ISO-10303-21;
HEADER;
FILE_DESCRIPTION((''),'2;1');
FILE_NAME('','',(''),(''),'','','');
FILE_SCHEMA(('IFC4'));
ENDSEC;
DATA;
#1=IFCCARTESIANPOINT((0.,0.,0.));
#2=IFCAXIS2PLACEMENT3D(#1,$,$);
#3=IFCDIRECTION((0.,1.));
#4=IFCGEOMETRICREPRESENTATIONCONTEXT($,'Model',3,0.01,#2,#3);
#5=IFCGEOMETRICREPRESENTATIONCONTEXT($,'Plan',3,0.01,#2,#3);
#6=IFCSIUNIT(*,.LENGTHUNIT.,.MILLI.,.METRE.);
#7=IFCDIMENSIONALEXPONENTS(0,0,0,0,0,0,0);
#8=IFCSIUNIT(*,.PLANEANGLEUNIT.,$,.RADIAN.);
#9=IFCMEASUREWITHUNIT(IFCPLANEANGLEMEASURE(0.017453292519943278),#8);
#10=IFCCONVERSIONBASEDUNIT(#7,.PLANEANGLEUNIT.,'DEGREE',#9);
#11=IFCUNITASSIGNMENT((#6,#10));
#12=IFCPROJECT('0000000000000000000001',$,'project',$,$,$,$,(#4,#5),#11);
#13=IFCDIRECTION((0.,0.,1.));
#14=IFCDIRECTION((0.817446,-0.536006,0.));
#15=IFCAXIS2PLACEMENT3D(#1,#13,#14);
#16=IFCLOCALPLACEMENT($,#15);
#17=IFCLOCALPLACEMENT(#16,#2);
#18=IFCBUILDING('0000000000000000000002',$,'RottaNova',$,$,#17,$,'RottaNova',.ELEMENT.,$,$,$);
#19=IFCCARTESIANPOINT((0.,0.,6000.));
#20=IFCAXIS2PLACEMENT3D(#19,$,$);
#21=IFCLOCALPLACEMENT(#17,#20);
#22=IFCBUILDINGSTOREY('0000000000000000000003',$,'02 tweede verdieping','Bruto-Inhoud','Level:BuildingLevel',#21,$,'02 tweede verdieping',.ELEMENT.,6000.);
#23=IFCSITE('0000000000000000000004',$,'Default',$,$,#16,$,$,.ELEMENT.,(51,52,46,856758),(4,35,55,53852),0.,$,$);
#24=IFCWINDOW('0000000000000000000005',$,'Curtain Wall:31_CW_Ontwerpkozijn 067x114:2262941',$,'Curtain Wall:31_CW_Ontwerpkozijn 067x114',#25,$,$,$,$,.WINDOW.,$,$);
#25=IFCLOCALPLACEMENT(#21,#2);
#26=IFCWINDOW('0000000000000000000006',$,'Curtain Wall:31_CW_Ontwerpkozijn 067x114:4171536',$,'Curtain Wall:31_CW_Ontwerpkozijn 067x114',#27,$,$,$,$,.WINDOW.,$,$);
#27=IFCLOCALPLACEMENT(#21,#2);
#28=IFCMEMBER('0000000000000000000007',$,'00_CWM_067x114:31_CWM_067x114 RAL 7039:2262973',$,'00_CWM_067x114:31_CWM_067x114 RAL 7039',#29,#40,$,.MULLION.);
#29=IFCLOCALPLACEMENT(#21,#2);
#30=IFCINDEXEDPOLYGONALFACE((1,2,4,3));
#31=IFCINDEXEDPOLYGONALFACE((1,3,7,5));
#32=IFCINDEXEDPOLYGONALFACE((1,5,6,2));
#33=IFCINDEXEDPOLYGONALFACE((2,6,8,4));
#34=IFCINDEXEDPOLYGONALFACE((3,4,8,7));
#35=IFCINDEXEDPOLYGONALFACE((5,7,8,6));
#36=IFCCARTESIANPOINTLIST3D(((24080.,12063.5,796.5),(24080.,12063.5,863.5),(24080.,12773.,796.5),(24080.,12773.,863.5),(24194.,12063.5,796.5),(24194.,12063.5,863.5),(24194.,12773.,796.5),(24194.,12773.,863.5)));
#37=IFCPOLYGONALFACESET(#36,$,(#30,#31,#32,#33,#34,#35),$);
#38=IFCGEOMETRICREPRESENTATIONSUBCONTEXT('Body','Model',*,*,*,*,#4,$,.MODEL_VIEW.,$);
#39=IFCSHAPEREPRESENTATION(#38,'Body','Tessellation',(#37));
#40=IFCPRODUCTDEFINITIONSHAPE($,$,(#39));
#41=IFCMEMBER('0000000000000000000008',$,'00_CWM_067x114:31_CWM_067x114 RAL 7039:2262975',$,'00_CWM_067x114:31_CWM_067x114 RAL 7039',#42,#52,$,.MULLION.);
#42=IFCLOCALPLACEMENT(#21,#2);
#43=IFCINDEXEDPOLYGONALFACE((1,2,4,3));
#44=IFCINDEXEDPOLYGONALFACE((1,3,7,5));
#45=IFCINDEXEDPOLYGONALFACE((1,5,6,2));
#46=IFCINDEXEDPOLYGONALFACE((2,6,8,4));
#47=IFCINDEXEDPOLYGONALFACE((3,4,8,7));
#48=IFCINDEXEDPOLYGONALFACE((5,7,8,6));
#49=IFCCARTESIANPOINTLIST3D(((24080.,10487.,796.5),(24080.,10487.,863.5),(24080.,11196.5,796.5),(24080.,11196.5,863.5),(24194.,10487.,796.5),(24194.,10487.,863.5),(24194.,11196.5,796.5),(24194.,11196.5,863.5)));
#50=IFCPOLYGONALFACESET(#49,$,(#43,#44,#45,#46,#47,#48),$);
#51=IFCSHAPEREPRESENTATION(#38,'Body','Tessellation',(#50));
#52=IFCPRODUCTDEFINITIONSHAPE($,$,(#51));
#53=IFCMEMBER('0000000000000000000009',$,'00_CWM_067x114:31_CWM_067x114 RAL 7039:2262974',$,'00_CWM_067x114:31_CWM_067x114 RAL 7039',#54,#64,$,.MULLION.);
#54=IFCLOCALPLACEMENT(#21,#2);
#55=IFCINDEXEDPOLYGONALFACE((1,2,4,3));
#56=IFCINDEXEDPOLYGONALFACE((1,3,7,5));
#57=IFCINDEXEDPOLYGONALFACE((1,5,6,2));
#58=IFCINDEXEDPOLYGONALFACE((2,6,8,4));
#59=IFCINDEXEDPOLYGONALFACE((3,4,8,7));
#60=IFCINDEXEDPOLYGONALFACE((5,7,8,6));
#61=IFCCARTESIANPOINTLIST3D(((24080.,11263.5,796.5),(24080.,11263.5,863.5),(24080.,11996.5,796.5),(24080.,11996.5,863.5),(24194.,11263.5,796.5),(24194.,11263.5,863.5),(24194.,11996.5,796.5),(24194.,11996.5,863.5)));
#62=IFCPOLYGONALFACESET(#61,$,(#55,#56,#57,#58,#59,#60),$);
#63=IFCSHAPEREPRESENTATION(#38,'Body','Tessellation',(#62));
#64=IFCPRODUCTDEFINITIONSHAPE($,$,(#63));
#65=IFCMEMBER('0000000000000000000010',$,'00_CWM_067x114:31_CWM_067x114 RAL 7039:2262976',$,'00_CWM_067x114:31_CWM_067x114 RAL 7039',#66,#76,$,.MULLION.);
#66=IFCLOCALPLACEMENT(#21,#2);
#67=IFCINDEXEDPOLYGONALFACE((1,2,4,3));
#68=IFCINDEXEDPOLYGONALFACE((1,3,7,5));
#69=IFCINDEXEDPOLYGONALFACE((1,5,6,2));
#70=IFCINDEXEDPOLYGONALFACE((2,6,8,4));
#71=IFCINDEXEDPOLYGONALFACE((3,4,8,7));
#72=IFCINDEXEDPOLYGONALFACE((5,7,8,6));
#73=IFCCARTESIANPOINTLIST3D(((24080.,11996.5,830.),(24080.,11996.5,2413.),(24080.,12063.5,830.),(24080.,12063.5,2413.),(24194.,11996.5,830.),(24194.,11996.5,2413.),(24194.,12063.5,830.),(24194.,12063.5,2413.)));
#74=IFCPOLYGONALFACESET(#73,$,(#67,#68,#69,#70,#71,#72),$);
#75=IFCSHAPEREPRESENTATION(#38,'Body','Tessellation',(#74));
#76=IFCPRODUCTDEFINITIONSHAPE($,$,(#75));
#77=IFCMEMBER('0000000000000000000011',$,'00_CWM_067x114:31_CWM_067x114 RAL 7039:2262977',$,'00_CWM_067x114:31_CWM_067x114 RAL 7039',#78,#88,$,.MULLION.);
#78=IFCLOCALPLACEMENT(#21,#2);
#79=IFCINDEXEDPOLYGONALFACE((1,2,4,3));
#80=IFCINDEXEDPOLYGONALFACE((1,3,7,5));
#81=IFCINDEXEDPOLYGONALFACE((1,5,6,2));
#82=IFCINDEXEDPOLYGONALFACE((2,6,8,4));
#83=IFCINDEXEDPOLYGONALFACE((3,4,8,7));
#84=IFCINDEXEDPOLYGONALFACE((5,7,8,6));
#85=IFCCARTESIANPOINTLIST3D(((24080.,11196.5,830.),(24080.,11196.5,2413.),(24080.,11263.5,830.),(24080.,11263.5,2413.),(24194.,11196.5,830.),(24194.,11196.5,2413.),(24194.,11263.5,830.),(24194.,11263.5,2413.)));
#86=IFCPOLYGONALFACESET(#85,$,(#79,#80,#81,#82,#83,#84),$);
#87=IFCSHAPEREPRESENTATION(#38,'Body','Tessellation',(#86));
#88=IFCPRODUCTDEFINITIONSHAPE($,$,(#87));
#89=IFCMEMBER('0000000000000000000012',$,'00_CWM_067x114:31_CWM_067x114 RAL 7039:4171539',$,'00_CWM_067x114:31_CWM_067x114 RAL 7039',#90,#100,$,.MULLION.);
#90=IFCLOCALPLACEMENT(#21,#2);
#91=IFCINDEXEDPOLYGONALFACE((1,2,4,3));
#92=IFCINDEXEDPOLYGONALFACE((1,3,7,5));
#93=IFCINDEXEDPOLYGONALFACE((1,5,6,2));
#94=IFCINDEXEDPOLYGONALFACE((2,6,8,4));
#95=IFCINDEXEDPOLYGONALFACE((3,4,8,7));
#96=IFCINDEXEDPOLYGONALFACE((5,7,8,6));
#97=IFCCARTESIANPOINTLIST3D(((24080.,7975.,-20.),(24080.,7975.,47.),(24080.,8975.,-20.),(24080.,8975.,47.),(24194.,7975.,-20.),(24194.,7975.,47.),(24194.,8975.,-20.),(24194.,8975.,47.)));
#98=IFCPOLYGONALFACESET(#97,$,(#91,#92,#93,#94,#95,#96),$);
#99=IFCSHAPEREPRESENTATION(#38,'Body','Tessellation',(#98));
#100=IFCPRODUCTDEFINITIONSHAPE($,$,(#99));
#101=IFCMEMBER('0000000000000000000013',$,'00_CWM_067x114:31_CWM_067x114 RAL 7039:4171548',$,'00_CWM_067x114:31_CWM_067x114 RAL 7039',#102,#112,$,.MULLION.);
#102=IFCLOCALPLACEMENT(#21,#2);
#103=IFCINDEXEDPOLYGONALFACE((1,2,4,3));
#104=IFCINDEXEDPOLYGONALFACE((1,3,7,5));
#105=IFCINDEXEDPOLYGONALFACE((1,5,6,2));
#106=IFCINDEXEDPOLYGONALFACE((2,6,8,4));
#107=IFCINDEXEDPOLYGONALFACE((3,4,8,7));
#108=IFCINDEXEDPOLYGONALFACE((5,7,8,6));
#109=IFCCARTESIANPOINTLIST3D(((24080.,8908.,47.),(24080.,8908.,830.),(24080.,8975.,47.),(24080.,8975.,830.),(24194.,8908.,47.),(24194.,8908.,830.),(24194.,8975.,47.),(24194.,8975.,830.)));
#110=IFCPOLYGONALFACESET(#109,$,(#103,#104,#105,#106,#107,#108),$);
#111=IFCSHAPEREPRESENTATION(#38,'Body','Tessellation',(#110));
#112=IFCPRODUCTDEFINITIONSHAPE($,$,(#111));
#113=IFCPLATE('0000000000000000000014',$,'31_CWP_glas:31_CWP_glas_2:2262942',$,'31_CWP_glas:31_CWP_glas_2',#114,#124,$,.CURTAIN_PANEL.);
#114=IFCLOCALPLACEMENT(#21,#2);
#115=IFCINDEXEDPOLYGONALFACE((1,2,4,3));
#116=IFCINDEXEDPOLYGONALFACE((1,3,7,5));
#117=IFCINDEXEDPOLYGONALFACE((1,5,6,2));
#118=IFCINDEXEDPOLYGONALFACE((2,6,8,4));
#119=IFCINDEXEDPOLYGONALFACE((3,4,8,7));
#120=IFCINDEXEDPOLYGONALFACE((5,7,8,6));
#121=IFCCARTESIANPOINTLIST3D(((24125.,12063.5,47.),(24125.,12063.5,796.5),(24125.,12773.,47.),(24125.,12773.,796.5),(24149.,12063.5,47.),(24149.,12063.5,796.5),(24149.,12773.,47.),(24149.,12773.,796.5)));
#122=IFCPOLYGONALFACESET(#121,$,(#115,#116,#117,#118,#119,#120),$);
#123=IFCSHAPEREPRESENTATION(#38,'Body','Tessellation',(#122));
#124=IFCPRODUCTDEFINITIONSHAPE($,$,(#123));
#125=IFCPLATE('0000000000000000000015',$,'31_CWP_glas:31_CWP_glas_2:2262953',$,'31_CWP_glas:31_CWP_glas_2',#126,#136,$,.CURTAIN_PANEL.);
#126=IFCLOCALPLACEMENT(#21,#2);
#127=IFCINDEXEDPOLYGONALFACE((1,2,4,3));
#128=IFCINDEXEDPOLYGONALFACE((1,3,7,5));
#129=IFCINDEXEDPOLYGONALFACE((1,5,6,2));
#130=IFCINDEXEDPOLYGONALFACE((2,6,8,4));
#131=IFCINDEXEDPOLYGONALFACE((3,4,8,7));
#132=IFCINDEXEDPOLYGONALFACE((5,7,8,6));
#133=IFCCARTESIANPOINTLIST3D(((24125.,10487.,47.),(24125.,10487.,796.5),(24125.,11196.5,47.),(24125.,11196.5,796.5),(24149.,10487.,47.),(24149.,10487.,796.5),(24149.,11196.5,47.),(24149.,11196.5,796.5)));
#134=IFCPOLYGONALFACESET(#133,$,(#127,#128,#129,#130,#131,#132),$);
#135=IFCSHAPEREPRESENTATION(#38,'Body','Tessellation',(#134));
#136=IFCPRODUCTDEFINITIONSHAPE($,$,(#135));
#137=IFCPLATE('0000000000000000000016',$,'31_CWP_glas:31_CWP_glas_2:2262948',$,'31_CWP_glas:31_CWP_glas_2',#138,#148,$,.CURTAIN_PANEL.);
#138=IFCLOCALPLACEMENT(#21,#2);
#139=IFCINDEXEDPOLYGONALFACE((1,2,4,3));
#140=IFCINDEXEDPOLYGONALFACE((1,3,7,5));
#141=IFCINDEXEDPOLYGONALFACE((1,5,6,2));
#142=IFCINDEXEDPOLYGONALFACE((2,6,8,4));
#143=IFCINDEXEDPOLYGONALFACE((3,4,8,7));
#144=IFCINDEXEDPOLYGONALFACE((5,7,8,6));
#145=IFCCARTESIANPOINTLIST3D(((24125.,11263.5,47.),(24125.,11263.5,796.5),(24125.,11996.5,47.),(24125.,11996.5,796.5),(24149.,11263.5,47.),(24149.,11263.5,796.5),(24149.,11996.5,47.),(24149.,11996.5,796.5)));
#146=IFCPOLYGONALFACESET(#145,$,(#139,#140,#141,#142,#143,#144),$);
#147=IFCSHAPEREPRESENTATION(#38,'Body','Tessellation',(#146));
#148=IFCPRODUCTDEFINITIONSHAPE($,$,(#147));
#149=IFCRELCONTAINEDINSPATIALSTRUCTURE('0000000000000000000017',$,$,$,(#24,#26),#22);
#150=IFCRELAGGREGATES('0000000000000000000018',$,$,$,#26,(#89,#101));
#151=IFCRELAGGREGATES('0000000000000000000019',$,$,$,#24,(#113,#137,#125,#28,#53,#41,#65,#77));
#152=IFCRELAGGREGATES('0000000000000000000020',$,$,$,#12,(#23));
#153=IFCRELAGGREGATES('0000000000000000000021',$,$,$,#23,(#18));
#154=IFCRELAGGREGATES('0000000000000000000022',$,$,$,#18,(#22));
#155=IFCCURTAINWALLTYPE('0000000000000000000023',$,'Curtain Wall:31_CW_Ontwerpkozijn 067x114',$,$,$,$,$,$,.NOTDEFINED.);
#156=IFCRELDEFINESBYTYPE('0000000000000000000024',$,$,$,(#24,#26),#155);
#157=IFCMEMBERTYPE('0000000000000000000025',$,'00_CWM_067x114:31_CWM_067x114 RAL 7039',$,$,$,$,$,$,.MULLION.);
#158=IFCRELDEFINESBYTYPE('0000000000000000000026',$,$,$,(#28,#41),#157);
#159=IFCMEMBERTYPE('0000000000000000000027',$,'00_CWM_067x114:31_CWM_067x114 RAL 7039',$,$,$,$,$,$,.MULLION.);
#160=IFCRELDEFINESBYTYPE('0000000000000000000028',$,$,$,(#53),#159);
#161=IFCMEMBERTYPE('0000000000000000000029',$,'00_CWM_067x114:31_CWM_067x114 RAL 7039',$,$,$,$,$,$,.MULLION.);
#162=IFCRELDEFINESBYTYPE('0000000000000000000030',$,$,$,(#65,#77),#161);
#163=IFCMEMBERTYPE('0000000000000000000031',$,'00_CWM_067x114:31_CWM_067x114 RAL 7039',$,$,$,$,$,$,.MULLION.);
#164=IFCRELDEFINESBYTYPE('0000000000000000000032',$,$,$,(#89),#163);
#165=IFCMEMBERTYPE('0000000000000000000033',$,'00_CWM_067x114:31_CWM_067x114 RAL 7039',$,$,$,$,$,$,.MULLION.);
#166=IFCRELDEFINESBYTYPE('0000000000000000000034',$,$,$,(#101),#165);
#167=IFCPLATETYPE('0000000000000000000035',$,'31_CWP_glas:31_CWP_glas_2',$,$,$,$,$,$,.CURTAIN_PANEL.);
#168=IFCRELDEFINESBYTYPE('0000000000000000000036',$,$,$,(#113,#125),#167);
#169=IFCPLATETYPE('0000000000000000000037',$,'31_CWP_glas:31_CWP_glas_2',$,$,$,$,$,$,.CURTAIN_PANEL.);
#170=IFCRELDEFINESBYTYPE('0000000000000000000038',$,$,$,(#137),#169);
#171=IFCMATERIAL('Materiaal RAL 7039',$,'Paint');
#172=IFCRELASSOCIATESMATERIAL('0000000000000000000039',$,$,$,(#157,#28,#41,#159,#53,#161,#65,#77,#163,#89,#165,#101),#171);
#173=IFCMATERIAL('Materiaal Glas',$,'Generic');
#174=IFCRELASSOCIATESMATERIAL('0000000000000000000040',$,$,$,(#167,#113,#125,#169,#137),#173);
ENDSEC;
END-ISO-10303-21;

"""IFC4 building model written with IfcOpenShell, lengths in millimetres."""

from ifc_helpers import new_model, entity, si_unit, converted_unit, direction, frame, origin, place, context, subcontext, project, spatial, indexed_curve, outline, extrude, source, transform, mapped, material, type_object, type_shapes, element, aggregate, save


model = new_model("IFC4")

# Units and contexts
model_context = context("Model", 3, precision=0.01, world=origin(), true_north=direction((0.0, 1.0)))
plan_context = context("Plan", 3, precision=0.01, world=origin(), true_north=direction((0.0, 1.0)))
body_context = subcontext(model_context, "Body", "Model", "MODEL_VIEW")
ifc_project = project(units=[si_unit("LENGTHUNIT", "METRE", prefix="MILLI"), converted_unit("PLANEANGLEUNIT", "DEGREE", entity("IfcPlaneAngleMeasure", 0.017453292519943278), si_unit("PLANEANGLEUNIT", "RADIAN"), dimensions=[0, 0, 0, 0, 0, 0, 0])], contexts=[model_context, plan_context])

# Site, building, storey
site_placement = place(None, frame((0.0, 0.0, 0.0), z_axis=(0.0, 0.0, 1.0), x_axis=(0.817446, -0.536006, 0.0)))
site = spatial("IfcSite", under=ifc_project, at=site_placement, Name="Default", CompositionType="ELEMENT", RefLatitude=(51, 52, 46, 856758), RefLongitude=(4, 35, 55, 53852), RefElevation=0.0)
building_placement = place(site_placement, origin())
building = spatial("IfcBuilding", under=site, at=building_placement, Name="RottaNova", LongName="RottaNova", CompositionType="ELEMENT")
storey_placement = place(building_placement, frame((0.0, 0.0, 6000.0)))
storey = spatial("IfcBuildingStorey", under=building, at=storey_placement, Name="02 tweede verdieping", Description="Bruto-Inhoud", ObjectType="Level:BuildingLevel", LongName="02 tweede verdieping", CompositionType="ELEMENT", Elevation=6000.0)

# Window
curtain_wall_type = type_object("IfcCurtainWallType", Name="Curtain Wall:31_CW_Ontwerpkozijn 067x114", PredefinedType="NOTDEFINED")
window_1_placement = place(storey_placement, frame((0.0, 0.0, -6000.0)))
window_1 = element("IfcWindow", 1, at=window_1_placement, inside=storey, type_object=curtain_wall_type, Name="Curtain Wall:31_CW_Ontwerpkozijn 067x114:2262941", ObjectType="Curtain Wall:31_CW_Ontwerpkozijn 067x114", PredefinedType="WINDOW")
ifc_material_1 = material(Name="Materiaal RAL 7039", Category="Paint")

# Window
window_2_placement = place(storey_placement, frame((0.0, 0.0, -6000.0)))
window_2 = element("IfcWindow", 2, at=window_2_placement, inside=storey, type_object=curtain_wall_type, Name="Curtain Wall:31_CW_Ontwerpkozijn 067x114:4171536", ObjectType="Curtain Wall:31_CW_Ontwerpkozijn 067x114", PredefinedType="WINDOW")

# Members
member_type_1 = type_object("IfcMemberType", Name="00_CWM_067x114:31_CWM_067x114 RAL 7039", PredefinedType="MULLION", material=ifc_material_1)
shared_shape_1 = source(origin(), body_context, "Body", "SweptSolid", [
    extrude(outline(indexed_curve([(-33.5, -57.0), (33.5, -57.0), (33.5, 57.0), (-33.5, 57.0), (-33.5, -57.0)], self_intersect=False)), frame((0.0, -57.0, -709.5), z_axis=(0.0, 0.0, 1.0), x_axis=(-1.0, 0.0, 0.0)), (0.0, 0.0, 1.0), 709.5),
])
type_shapes(member_type_1, [shared_shape_1])
member_1_placement = place(window_1_placement, frame((24080.0, 12063.5, 6830.0), z_axis=(0.0, -1.0, 0.0), x_axis=(0.0, 0.0, 1.0)))
member_1 = element("IfcMember", 3, at=member_1_placement, type_object=member_type_1, material=ifc_material_1, Name="00_CWM_067x114:31_CWM_067x114 RAL 7039:2262973", ObjectType="00_CWM_067x114:31_CWM_067x114 RAL 7039", PredefinedType="MULLION", context=body_context, shape_type="MappedRepresentation", body=[
    mapped(shared_shape_1, transform((0.0, 0.0, 0.0), scale=1.0)),
])
member_2_placement = place(window_1_placement, frame((24080.0, 10487.0, 6830.0), z_axis=(0.0, -1.0, 0.0), x_axis=(0.0, 0.0, 1.0)))
member_2 = element("IfcMember", 4, at=member_2_placement, type_object=member_type_1, material=ifc_material_1, Name="00_CWM_067x114:31_CWM_067x114 RAL 7039:2262975", ObjectType="00_CWM_067x114:31_CWM_067x114 RAL 7039", PredefinedType="MULLION", context=body_context, shape_type="MappedRepresentation", body=[
    mapped(shared_shape_1, transform((0.0, 0.0, 0.0), scale=1.0)),
])
member_type_2 = type_object("IfcMemberType", Name="00_CWM_067x114:31_CWM_067x114 RAL 7039", PredefinedType="MULLION", material=ifc_material_1)
shared_shape_2 = source(origin(), body_context, "Body", "SweptSolid", [
    extrude(outline(indexed_curve([(-33.5, -57.0), (33.5, -57.0), (33.5, 57.0), (-33.5, 57.0), (-33.5, -57.0)], self_intersect=False)), frame((0.0, -57.0, -733.0), z_axis=(0.0, 0.0, 1.0), x_axis=(-1.0, 0.0, 0.0)), (0.0, 0.0, 1.0), 733.0),
])
type_shapes(member_type_2, [shared_shape_2])
member_3_placement = place(window_1_placement, frame((24080.0, 11263.5, 6830.0), z_axis=(0.0, -1.0, 0.0), x_axis=(0.0, 0.0, 1.0)))
member_3 = element("IfcMember", 5, at=member_3_placement, type_object=member_type_2, material=ifc_material_1, Name="00_CWM_067x114:31_CWM_067x114 RAL 7039:2262974", ObjectType="00_CWM_067x114:31_CWM_067x114 RAL 7039", PredefinedType="MULLION", context=body_context, shape_type="MappedRepresentation", body=[
    mapped(shared_shape_2, transform((0.0, 0.0, 0.0), scale=1.0)),
])
member_type_3 = type_object("IfcMemberType", Name="00_CWM_067x114:31_CWM_067x114 RAL 7039", PredefinedType="MULLION", material=ifc_material_1)
shared_shape_3 = source(origin(), body_context, "Body", "SweptSolid", [
    extrude(outline(indexed_curve([(-33.5, -57.0), (33.5, -57.0), (33.5, 57.0), (-33.5, 57.0), (-33.5, -57.0)], self_intersect=False)), frame((0.0, -57.0, -1583.0), z_axis=(0.0, 0.0, 1.0), x_axis=(-1.0, 0.0, 0.0)), (0.0, 0.0, 1.0), 1583.0),
])
type_shapes(member_type_3, [shared_shape_3])
member_4_placement = place(window_1_placement, frame((24080.0, 12030.0, 6830.0), z_axis=(0.0, 0.0, -1.0), x_axis=(0.0, -1.0, 0.0)))
member_4 = element("IfcMember", 6, at=member_4_placement, type_object=member_type_3, material=ifc_material_1, Name="00_CWM_067x114:31_CWM_067x114 RAL 7039:2262976", ObjectType="00_CWM_067x114:31_CWM_067x114 RAL 7039", PredefinedType="MULLION", context=body_context, shape_type="MappedRepresentation", body=[
    mapped(shared_shape_3, transform((0.0, 0.0, 0.0), scale=1.0)),
])
member_5_placement = place(window_1_placement, frame((24080.0, 11230.0, 6830.0), z_axis=(0.0, 0.0, -1.0), x_axis=(0.0, -1.0, 0.0)))
member_5 = element("IfcMember", 7, at=member_5_placement, type_object=member_type_3, material=ifc_material_1, Name="00_CWM_067x114:31_CWM_067x114 RAL 7039:2262977", ObjectType="00_CWM_067x114:31_CWM_067x114 RAL 7039", PredefinedType="MULLION", context=body_context, shape_type="MappedRepresentation", body=[
    mapped(shared_shape_3, transform((0.0, 0.0, 0.0), scale=1.0)),
])
member_type_4 = type_object("IfcMemberType", Name="00_CWM_067x114:31_CWM_067x114 RAL 7039", PredefinedType="MULLION", material=ifc_material_1)
shared_shape_4 = source(origin(), body_context, "Body", "SweptSolid", [
    extrude(outline(indexed_curve([(-33.5, -57.0), (33.5, -57.0), (33.5, 57.0), (-33.5, 57.0), (-33.5, -57.0)], self_intersect=False)), frame((-33.5, -57.0, -1000.0), z_axis=(0.0, 0.0, 1.0), x_axis=(-1.0, 0.0, 0.0)), (0.0, 0.0, 1.0), 1000.0),
])
type_shapes(member_type_4, [shared_shape_4])
member_6_placement = place(window_2_placement, frame((24080.0, 8975.0, 5980.0), z_axis=(0.0, 1.0, 0.0), x_axis=(0.0, 0.0, -1.0)))
member_6 = element("IfcMember", 8, at=member_6_placement, type_object=member_type_4, material=ifc_material_1, Name="00_CWM_067x114:31_CWM_067x114 RAL 7039:4171539", ObjectType="00_CWM_067x114:31_CWM_067x114 RAL 7039", PredefinedType="MULLION", context=body_context, shape_type="MappedRepresentation", body=[
    mapped(shared_shape_4, transform((0.0, 0.0, 0.0), scale=1.0)),
])
member_type_5 = type_object("IfcMemberType", Name="00_CWM_067x114:31_CWM_067x114 RAL 7039", PredefinedType="MULLION", material=ifc_material_1)
shared_shape_5 = source(origin(), body_context, "Body", "SweptSolid", [
    extrude(outline(indexed_curve([(-33.5, -57.0), (33.5, -57.0), (33.5, 57.0), (-33.5, 57.0), (-33.5, -57.0)], self_intersect=False)), frame((-33.5, -57.0, -783.0), z_axis=(0.0, 0.0, 1.0), x_axis=(-1.0, 0.0, 0.0)), (0.0, 0.0, 1.0), 783.0),
])
type_shapes(member_type_5, [shared_shape_5])
member_7_placement = place(window_2_placement, frame((24080.0, 8975.0, 6830.0), z_axis=(0.0, 0.0, 1.0), x_axis=(0.0, 1.0, 0.0)))
member_7 = element("IfcMember", 9, at=member_7_placement, type_object=member_type_5, material=ifc_material_1, Name="00_CWM_067x114:31_CWM_067x114 RAL 7039:4171548", ObjectType="00_CWM_067x114:31_CWM_067x114 RAL 7039", PredefinedType="MULLION", context=body_context, shape_type="MappedRepresentation", body=[
    mapped(shared_shape_5, transform((0.0, 0.0, 0.0), scale=1.0)),
])
aggregate(window_2, [member_6, member_7])

# Plates
ifc_material_2 = material(Name="Materiaal Glas", Category="Generic")
plate_type_1 = type_object("IfcPlateType", Name="31_CWP_glas:31_CWP_glas_2", PredefinedType="CURTAIN_PANEL", material=ifc_material_2)
shared_shape_6 = source(origin(), body_context, "Body", "SweptSolid", [
    extrude(outline(indexed_curve([(-12.0, -354.8), (12.0, -354.8), (12.0, 354.8), (-12.0, 354.8), (-12.0, -354.8)], self_intersect=False)), frame((0.0, 57.0, 0.0), z_axis=(0.0, 0.0, 1.0), x_axis=(0.0, 1.0, 0.0)), (0.0, 0.0, 1.0), 749.5),
])
type_shapes(plate_type_1, [shared_shape_6])
plate_1_placement = place(window_1_placement, frame((24080.0, 12418.2, 6047.0), z_axis=(0.0, 0.0, 1.0), x_axis=(0.0, -1.0, 0.0)))
plate_1 = element("IfcPlate", 10, at=plate_1_placement, type_object=plate_type_1, material=ifc_material_2, Name="31_CWP_glas:31_CWP_glas_2:2262942", ObjectType="31_CWP_glas:31_CWP_glas_2", PredefinedType="CURTAIN_PANEL", context=body_context, shape_type="MappedRepresentation", body=[
    mapped(shared_shape_6, transform((0.0, 0.0, 0.0), scale=1.0)),
])
plate_2_placement = place(window_1_placement, frame((24080.0, 10841.7, 6047.0), z_axis=(0.0, 0.0, 1.0), x_axis=(0.0, -1.0, 0.0)))
plate_2 = element("IfcPlate", 11, at=plate_2_placement, type_object=plate_type_1, material=ifc_material_2, Name="31_CWP_glas:31_CWP_glas_2:2262953", ObjectType="31_CWP_glas:31_CWP_glas_2", PredefinedType="CURTAIN_PANEL", context=body_context, shape_type="MappedRepresentation", body=[
    mapped(shared_shape_6, transform((0.0, 0.0, 0.0), scale=1.0)),
])
plate_type_2 = type_object("IfcPlateType", Name="31_CWP_glas:31_CWP_glas_2", PredefinedType="CURTAIN_PANEL", material=ifc_material_2)
shared_shape_7 = source(origin(), body_context, "Body", "SweptSolid", [
    extrude(outline(indexed_curve([(-12.0, -366.5), (12.0, -366.5), (12.0, 366.5), (-12.0, 366.5), (-12.0, -366.5)], self_intersect=False)), frame((0.0, 57.0, 0.0), z_axis=(0.0, 0.0, 1.0), x_axis=(0.0, 1.0, 0.0)), (0.0, 0.0, 1.0), 749.5),
])
type_shapes(plate_type_2, [shared_shape_7])
plate_3_placement = place(window_1_placement, frame((24080.0, 11630.0, 6047.0), z_axis=(0.0, 0.0, 1.0), x_axis=(0.0, -1.0, 0.0)))
plate_3 = element("IfcPlate", 12, at=plate_3_placement, type_object=plate_type_2, material=ifc_material_2, Name="31_CWP_glas:31_CWP_glas_2:2262948", ObjectType="31_CWP_glas:31_CWP_glas_2", PredefinedType="CURTAIN_PANEL", context=body_context, shape_type="MappedRepresentation", body=[
    mapped(shared_shape_7, transform((0.0, 0.0, 0.0), scale=1.0)),
])
aggregate(window_1, [plate_1, plate_3, plate_2, member_1, member_3, member_2, member_4, member_5])

save(model, "model.ifc")
